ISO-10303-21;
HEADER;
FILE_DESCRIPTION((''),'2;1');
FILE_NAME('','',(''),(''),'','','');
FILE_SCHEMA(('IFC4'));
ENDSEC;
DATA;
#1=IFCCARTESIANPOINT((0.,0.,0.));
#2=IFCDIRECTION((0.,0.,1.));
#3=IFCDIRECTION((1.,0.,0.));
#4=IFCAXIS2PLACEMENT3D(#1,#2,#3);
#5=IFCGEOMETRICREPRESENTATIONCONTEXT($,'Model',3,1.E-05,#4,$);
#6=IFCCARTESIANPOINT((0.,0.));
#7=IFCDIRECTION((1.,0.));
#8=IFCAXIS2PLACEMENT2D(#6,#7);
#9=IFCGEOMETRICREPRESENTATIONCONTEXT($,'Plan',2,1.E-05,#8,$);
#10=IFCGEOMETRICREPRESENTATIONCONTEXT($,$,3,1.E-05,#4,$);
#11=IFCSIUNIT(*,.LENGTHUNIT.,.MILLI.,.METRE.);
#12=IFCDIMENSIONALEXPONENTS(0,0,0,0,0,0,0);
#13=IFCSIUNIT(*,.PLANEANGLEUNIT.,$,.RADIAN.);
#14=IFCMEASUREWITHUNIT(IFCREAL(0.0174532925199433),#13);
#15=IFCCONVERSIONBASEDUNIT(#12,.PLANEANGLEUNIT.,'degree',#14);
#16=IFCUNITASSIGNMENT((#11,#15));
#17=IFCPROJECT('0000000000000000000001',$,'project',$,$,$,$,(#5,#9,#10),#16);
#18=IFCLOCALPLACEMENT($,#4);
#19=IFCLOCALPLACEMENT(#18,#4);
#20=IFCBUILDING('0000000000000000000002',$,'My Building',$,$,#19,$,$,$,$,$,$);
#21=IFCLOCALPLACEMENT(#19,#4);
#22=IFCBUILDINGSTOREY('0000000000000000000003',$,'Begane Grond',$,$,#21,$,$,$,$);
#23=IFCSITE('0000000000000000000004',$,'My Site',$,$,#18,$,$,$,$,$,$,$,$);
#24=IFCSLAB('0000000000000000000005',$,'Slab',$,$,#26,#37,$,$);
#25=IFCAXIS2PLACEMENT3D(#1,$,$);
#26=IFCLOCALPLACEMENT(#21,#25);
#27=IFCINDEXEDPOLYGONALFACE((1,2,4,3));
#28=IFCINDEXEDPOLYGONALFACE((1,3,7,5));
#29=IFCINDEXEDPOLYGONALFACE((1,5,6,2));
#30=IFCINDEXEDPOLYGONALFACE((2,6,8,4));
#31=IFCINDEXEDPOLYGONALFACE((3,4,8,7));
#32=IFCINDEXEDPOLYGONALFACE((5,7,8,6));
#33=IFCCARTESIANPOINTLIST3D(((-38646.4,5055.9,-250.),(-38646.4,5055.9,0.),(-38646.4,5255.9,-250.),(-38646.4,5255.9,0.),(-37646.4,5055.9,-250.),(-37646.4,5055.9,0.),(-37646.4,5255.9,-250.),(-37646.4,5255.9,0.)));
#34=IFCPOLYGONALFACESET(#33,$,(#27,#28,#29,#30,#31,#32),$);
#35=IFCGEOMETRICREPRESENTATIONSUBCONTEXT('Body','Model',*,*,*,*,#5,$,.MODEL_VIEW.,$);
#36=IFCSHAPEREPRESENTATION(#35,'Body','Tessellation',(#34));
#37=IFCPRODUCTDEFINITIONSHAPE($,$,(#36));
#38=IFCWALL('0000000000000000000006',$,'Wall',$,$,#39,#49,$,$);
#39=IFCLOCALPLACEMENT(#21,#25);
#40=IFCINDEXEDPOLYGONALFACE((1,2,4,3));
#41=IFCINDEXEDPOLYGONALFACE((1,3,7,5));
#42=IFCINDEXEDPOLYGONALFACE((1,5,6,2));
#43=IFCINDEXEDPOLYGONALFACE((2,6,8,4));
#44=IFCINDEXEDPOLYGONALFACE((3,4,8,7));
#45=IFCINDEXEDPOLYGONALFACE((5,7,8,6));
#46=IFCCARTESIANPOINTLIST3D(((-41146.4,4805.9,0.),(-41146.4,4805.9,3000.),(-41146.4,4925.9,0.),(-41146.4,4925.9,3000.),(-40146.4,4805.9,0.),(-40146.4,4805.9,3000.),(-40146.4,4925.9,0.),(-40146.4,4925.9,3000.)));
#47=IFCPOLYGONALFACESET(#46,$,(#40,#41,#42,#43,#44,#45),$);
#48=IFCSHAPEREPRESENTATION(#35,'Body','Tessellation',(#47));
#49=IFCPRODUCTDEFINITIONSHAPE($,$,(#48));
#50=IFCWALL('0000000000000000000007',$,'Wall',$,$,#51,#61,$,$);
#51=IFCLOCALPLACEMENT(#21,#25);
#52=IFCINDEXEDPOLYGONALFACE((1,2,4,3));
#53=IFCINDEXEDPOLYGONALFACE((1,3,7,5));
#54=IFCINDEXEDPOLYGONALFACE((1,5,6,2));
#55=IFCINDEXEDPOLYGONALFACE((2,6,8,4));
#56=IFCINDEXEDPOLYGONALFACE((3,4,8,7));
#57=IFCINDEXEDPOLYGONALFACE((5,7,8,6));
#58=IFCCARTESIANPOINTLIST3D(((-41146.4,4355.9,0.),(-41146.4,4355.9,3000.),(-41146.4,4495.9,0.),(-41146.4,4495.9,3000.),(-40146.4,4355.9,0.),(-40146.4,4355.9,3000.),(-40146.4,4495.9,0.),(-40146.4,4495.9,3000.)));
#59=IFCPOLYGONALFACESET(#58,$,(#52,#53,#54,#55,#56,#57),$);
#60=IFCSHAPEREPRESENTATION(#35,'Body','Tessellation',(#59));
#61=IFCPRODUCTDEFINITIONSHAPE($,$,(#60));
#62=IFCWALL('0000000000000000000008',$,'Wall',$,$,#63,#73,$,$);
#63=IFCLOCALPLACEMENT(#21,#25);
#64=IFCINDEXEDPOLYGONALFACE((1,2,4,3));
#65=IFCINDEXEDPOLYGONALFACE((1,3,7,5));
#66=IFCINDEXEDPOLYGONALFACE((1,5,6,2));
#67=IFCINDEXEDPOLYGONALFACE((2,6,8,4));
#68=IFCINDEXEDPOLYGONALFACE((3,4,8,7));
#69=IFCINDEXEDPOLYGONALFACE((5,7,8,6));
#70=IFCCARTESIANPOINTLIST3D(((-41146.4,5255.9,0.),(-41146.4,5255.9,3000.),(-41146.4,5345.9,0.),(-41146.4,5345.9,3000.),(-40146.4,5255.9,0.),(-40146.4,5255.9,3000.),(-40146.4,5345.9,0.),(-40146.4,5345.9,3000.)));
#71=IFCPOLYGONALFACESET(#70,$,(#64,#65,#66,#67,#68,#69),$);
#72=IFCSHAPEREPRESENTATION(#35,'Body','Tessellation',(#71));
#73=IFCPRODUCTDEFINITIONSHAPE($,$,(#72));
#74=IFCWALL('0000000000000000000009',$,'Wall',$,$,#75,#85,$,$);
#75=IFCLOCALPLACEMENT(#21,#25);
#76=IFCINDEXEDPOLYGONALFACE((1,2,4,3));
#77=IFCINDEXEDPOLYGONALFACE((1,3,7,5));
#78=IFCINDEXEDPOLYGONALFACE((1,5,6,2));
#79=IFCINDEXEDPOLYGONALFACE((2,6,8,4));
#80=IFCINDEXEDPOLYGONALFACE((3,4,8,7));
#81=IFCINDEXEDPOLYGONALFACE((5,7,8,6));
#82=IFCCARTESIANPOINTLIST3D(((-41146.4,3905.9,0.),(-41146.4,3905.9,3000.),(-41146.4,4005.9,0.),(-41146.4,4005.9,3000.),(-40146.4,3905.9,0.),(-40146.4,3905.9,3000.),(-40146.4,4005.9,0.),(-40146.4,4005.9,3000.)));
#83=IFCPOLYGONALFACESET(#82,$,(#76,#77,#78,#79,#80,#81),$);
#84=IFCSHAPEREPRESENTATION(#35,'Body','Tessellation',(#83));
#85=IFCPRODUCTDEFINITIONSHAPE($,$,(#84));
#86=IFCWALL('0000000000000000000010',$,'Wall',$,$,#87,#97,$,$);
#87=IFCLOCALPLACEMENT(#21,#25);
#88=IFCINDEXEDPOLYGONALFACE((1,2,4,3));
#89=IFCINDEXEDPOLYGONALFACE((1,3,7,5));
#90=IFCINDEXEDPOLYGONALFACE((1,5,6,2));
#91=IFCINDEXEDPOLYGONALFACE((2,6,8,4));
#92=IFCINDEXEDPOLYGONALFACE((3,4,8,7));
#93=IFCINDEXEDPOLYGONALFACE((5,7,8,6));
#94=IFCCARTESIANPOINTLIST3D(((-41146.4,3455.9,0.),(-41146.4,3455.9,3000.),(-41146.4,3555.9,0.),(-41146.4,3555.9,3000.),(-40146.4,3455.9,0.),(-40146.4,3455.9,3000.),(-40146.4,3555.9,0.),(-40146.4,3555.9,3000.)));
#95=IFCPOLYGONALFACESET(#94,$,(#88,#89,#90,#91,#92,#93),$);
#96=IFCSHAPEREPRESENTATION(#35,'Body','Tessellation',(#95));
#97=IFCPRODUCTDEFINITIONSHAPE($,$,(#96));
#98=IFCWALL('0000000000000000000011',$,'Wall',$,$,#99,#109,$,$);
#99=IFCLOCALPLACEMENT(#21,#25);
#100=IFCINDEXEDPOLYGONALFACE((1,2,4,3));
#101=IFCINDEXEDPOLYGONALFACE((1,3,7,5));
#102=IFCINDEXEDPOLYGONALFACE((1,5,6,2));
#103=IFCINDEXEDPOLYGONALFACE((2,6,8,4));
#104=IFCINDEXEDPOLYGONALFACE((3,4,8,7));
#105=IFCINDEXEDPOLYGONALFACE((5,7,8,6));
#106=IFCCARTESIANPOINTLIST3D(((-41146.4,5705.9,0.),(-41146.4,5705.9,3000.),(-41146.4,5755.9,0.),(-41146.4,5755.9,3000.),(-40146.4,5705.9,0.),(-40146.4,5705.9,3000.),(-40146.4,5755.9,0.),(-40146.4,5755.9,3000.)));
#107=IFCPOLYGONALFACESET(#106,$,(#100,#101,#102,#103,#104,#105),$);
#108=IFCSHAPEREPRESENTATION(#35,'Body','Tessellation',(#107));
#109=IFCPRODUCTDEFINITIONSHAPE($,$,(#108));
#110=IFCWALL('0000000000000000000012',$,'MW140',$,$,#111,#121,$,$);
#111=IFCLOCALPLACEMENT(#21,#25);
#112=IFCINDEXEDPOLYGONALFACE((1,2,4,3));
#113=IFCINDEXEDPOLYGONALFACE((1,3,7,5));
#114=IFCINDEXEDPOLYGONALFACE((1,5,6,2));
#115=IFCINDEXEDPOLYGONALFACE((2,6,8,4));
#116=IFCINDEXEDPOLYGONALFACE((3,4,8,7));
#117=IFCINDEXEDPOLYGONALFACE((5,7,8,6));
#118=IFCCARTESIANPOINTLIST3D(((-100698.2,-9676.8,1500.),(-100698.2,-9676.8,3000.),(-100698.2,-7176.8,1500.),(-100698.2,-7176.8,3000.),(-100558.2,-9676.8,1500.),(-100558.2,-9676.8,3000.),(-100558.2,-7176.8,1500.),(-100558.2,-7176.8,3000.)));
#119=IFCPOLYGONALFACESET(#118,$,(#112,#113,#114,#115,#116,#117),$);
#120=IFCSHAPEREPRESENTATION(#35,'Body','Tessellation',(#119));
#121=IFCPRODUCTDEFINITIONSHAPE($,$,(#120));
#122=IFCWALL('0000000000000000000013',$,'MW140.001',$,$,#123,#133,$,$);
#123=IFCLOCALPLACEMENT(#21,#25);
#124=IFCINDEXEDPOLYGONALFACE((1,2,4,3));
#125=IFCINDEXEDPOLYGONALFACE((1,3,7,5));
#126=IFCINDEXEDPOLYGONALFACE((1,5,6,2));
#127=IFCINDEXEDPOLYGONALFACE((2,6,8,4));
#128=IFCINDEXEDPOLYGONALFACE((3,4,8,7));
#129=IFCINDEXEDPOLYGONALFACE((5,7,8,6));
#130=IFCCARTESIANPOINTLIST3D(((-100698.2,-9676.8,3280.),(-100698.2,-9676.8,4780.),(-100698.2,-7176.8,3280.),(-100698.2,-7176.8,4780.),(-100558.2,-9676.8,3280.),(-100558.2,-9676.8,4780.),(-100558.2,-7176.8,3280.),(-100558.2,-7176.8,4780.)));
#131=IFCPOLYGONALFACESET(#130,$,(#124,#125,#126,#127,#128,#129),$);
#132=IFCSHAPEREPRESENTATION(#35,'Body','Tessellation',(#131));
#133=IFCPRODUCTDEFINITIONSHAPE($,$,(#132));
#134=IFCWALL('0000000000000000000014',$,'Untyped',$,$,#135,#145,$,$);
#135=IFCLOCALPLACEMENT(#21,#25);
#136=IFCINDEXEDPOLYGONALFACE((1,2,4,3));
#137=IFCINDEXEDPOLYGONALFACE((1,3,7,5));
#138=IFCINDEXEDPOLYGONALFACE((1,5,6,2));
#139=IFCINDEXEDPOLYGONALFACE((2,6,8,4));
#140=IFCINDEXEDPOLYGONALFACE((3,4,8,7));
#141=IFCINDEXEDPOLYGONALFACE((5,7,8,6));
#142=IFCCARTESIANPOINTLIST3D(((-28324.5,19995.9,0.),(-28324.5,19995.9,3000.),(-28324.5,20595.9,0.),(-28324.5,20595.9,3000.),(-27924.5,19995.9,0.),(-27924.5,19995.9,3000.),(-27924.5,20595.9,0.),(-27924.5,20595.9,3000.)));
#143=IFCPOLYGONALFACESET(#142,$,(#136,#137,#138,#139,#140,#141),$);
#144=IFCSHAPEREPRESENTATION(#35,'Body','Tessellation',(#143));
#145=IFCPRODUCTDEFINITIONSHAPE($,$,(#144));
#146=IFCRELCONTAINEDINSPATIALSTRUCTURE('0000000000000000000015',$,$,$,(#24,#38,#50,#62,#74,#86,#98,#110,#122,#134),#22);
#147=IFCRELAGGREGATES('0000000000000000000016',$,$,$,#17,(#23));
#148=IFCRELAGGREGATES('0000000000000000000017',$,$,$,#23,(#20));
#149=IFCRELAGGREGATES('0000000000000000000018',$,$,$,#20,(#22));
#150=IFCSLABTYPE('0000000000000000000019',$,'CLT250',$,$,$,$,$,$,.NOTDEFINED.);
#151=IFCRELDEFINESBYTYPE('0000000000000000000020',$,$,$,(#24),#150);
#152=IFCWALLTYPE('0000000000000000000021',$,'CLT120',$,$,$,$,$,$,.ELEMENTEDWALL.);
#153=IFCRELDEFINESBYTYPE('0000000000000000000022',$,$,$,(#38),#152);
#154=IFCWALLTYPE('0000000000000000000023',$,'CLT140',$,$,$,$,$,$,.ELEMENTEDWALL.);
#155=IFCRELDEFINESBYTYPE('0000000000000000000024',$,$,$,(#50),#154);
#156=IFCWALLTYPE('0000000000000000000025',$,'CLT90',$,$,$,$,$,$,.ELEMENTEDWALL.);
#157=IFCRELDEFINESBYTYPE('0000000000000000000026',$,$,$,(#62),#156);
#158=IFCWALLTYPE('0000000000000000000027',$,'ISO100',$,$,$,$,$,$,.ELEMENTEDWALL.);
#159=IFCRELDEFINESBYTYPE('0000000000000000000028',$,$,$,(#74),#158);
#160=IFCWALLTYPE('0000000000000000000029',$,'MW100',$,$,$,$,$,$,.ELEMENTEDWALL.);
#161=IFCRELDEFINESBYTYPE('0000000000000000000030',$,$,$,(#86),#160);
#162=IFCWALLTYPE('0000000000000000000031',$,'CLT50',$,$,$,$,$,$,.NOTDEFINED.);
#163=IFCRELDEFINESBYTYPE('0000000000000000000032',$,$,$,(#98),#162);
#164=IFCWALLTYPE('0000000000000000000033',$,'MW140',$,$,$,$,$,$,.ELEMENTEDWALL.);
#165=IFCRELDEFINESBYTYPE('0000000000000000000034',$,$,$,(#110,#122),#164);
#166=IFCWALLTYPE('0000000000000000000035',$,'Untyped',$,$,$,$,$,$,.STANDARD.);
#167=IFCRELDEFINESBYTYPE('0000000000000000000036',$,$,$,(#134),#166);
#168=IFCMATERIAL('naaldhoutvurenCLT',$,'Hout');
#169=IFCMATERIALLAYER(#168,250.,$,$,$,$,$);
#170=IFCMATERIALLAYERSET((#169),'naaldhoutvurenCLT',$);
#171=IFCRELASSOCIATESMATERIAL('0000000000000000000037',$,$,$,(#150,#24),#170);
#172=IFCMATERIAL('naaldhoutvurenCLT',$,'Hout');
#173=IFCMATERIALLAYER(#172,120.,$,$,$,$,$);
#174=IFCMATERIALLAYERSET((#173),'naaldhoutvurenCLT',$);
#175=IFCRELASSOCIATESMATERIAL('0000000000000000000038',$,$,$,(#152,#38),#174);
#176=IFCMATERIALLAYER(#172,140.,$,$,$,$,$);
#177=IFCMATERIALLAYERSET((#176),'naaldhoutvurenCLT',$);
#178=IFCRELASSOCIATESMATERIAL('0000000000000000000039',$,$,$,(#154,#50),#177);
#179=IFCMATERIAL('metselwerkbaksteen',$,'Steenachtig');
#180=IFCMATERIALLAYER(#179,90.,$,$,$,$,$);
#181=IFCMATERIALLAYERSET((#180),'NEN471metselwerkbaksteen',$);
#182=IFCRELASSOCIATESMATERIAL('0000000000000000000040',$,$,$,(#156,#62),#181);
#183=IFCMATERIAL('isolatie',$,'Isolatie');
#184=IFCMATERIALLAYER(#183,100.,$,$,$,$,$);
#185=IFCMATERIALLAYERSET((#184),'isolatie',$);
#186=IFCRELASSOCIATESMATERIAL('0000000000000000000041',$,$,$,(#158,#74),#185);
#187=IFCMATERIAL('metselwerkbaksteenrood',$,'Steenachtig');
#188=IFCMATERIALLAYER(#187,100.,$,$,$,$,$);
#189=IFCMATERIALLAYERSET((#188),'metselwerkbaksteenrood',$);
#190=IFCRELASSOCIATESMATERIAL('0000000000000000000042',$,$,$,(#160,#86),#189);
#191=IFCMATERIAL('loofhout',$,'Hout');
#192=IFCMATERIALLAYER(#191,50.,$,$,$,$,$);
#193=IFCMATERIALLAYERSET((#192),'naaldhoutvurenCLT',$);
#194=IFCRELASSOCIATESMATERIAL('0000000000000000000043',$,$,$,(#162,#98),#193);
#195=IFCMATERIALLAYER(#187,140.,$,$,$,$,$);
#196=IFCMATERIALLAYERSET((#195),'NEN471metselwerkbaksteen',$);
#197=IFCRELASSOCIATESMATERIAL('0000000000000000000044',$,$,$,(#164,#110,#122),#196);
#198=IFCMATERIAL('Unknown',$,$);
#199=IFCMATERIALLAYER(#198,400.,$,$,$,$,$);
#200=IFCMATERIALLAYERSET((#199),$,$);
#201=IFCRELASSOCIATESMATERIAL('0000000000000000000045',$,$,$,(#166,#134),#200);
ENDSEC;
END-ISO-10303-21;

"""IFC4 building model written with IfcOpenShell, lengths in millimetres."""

from ifc_helpers import new_model, entity, si_unit, converted_unit, frame, origin_with_axes, origin_2d_with_axis, place, context, subcontext, project, spatial, line, indexed_curve, outline, extrude, material, layer, layer_set, layer_usage, type_object, element, save


model = new_model("IFC4")

# Units and contexts
model_context = context("Model", 3, precision=1e-05, world=origin_with_axes())
plan_context = context("Plan", 2, precision=1e-05, world=origin_2d_with_axis())
context_of_model = context(None, 3, precision=1e-05, world=origin_with_axes())
body_context = subcontext(model_context, "Body", "Model", "MODEL_VIEW")
ifc_project = project(units=[si_unit("LENGTHUNIT", "METRE", prefix="MILLI"), converted_unit("PLANEANGLEUNIT", "degree", entity("IfcReal", 0.0174532925199433), si_unit("PLANEANGLEUNIT", "RADIAN"), dimensions=[0, 0, 0, 0, 0, 0, 0])], contexts=[model_context, plan_context, context_of_model])

# Site, building, storey
site_placement = place(None, frame((0.0, 0.0, 0.0), z_axis=(0.0, 0.0, 1.0), x_axis=(1.0, 0.0, 0.0)))
site = spatial("IfcSite", under=ifc_project, at=site_placement, Name="My Site")
building_placement = place(site_placement, origin_with_axes())
building = spatial("IfcBuilding", under=site, at=building_placement, Name="My Building")
storey_placement = place(building_placement, origin_with_axes())
storey = spatial("IfcBuildingStorey", under=building, at=storey_placement, Name="Begane Grond")

# Slab
ifc_material_1 = material(Name="naaldhoutvurenCLT", Category="Hout")
ifc_material_2 = material(Name="isolatie", Category="Isolatie")
ifc_material_3 = material(Name="naaldhoutvurenCLT", Category="Hout")
ifc_layer_1 = layer(ifc_material_3, 250.0)
ifc_layer_set_1 = layer_set([ifc_layer_1], Name="naaldhoutvurenCLT")
ifc_layer_usage_1 = layer_usage(ifc_layer_set_1, "AXIS3", "POSITIVE", 0.0)
slab_type_1 = type_object("IfcSlabType", Name="CLT250", PredefinedType="NOTDEFINED", material=ifc_layer_set_1)
slab_1_placement = place(storey_placement, frame((-38646.4, 5055.9, -250.0), z_axis=(0.0, 0.0, 1.0), x_axis=(1.0, 0.0, 0.0)))
element("IfcSlab", 1, at=slab_1_placement, inside=storey, type_object=slab_type_1, material=ifc_layer_usage_1, Name="Slab", context=body_context, shape_type="SweptSolid", body=[
    extrude(outline(indexed_curve([(1000.0, 200.0), (1000.0, 0.0), (0.0, 0.0), (0.0, 200.0)], segments=[line(3, 2), line(2, 1), line(1, 4), line(4, 3)], self_intersect=False)), None, (0.0, 0.0, 1.0), 250.0),
])

# Walls
ifc_layer_2 = layer(ifc_material_1, 120.0)
ifc_layer_set_2 = layer_set([ifc_layer_2], Name="naaldhoutvurenCLT")
ifc_layer_usage_2 = layer_usage(ifc_layer_set_2, "AXIS2", "POSITIVE", 0.0)
wall_type_1 = type_object("IfcWallType", Name="CLT120", PredefinedType="ELEMENTEDWALL", material=ifc_layer_set_2)
wall_1_placement = place(storey_placement, frame((-41146.4, 4805.9, 0.0), z_axis=(0.0, 0.0, 1.0), x_axis=(1.0, 0.0, 0.0)))
element("IfcWall", 2, at=wall_1_placement, inside=storey, type_object=wall_type_1, material=ifc_layer_usage_2, Name="Wall", context=body_context, shape_type="SweptSolid", body=[
    extrude(outline(indexed_curve([(0.0, 0.0), (0.0, 120.0), (1000.0, 120.0), (1000.0, 0.0), (0.0, 0.0)], self_intersect=False)), origin_with_axes(), (0.0, 0.0, 1.0), 3000.0),
])
ifc_layer_3 = layer(ifc_material_1, 140.0)
ifc_layer_set_3 = layer_set([ifc_layer_3], Name="naaldhoutvurenCLT")
ifc_layer_usage_3 = layer_usage(ifc_layer_set_3, "AXIS2", "POSITIVE", 0.0)
wall_type_2 = type_object("IfcWallType", Name="CLT140", PredefinedType="ELEMENTEDWALL", material=ifc_layer_set_3)
wall_2_placement = place(storey_placement, frame((-41146.4, 4355.9, 0.0), z_axis=(0.0, 0.0, 1.0), x_axis=(1.0, 0.0, 0.0)))
element("IfcWall", 3, at=wall_2_placement, inside=storey, type_object=wall_type_2, material=ifc_layer_usage_3, Name="Wall", context=body_context, shape_type="SweptSolid", body=[
    extrude(outline(indexed_curve([(0.0, 0.0), (0.0, 140.0), (1000.0, 140.0), (1000.0, 0.0), (0.0, 0.0)], self_intersect=False)), origin_with_axes(), (0.0, 0.0, 1.0), 3000.0),
])
ifc_material_4 = material(Name="metselwerkbaksteen", Category="Steenachtig")
ifc_layer_4 = layer(ifc_material_4, 90.0)
ifc_layer_set_4 = layer_set([ifc_layer_4], Name="NEN471metselwerkbaksteen")
ifc_layer_usage_4 = layer_usage(ifc_layer_set_4, "AXIS2", "POSITIVE", 0.0)
wall_type_3 = type_object("IfcWallType", Name="CLT90", PredefinedType="ELEMENTEDWALL", material=ifc_layer_set_4)
wall_3_placement = place(storey_placement, frame((-41146.4, 5255.9, 0.0), z_axis=(0.0, 0.0, 1.0), x_axis=(1.0, 0.0, 0.0)))
element("IfcWall", 4, at=wall_3_placement, inside=storey, type_object=wall_type_3, material=ifc_layer_usage_4, Name="Wall", context=body_context, shape_type="SweptSolid", body=[
    extrude(outline(indexed_curve([(0.0, 0.0), (0.0, 90.0), (1000.0, 90.0), (1000.0, 0.0), (0.0, 0.0)], self_intersect=False)), origin_with_axes(), (0.0, 0.0, 1.0), 3000.0),
])
ifc_layer_5 = layer(ifc_material_2, 100.0)
ifc_layer_set_5 = layer_set([ifc_layer_5], Name="isolatie")
ifc_layer_usage_5 = layer_usage(ifc_layer_set_5, "AXIS2", "POSITIVE", 0.0)
wall_type_4 = type_object("IfcWallType", Name="ISO100", PredefinedType="ELEMENTEDWALL", material=ifc_layer_set_5)
wall_4_placement = place(storey_placement, frame((-41146.4, 3905.9, 0.0), z_axis=(0.0, 0.0, 1.0), x_axis=(1.0, 0.0, 0.0)))
element("IfcWall", 5, at=wall_4_placement, inside=storey, type_object=wall_type_4, material=ifc_layer_usage_5, Name="Wall", context=body_context, shape_type="SweptSolid", body=[
    extrude(outline(indexed_curve([(0.0, 0.0), (0.0, 100.0), (1000.0, 100.0), (1000.0, 0.0), (0.0, 0.0)], self_intersect=False)), origin_with_axes(), (0.0, 0.0, 1.0), 3000.0),
])
ifc_material_5 = material(Name="metselwerkbaksteenrood", Category="Steenachtig")
ifc_layer_6 = layer(ifc_material_5, 100.0)
ifc_layer_set_6 = layer_set([ifc_layer_6], Name="metselwerkbaksteenrood")
ifc_layer_usage_6 = layer_usage(ifc_layer_set_6, "AXIS2", "POSITIVE", 0.0)
wall_type_5 = type_object("IfcWallType", Name="MW100", PredefinedType="ELEMENTEDWALL", material=ifc_layer_set_6)
wall_5_placement = place(storey_placement, frame((-41146.4, 3455.9, 0.0), z_axis=(0.0, 0.0, 1.0), x_axis=(1.0, 0.0, 0.0)))
element("IfcWall", 6, at=wall_5_placement, inside=storey, type_object=wall_type_5, material=ifc_layer_usage_6, Name="Wall", context=body_context, shape_type="SweptSolid", body=[
    extrude(outline(indexed_curve([(0.0, 0.0), (0.0, 100.0), (1000.0, 100.0), (1000.0, 0.0), (0.0, 0.0)], self_intersect=False)), origin_with_axes(), (0.0, 0.0, 1.0), 3000.0),
])
ifc_material_6 = material(Name="loofhout", Category="Hout")
ifc_layer_7 = layer(ifc_material_6, 50.0)
ifc_layer_set_7 = layer_set([ifc_layer_7], Name="naaldhoutvurenCLT")
ifc_layer_usage_7 = layer_usage(ifc_layer_set_7, "AXIS2", "POSITIVE", 0.0)
wall_type_6 = type_object("IfcWallType", Name="CLT50", PredefinedType="NOTDEFINED", material=ifc_layer_set_7)
wall_6_placement = place(storey_placement, frame((-41146.4, 5705.9, 0.0), z_axis=(0.0, 0.0, 1.0), x_axis=(1.0, 0.0, 0.0)))
element("IfcWall", 7, at=wall_6_placement, inside=storey, type_object=wall_type_6, material=ifc_layer_usage_7, Name="Wall", context=body_context, shape_type="SweptSolid", body=[
    extrude(outline(indexed_curve([(0.0, 0.0), (0.0, 50.0), (1000.0, 50.0), (1000.0, 0.0), (0.0, 0.0)], self_intersect=False)), origin_with_axes(), (0.0, 0.0, 1.0), 3000.0),
])
ifc_layer_8 = layer(ifc_material_5, 140.0)
ifc_layer_set_8 = layer_set([ifc_layer_8], Name="NEN471metselwerkbaksteen")
ifc_layer_usage_8 = layer_usage(ifc_layer_set_8, "AXIS2", "POSITIVE", 0.0)
wall_type_7 = type_object("IfcWallType", Name="MW140", PredefinedType="ELEMENTEDWALL", material=ifc_layer_set_8)
wall_7_placement = place(storey_placement, frame((-100558.2, -9676.8, 1500.0), z_axis=(0.0, 0.0, 1.0), x_axis=(0.0, 1.0, 0.0)))
element("IfcWall", 8, at=wall_7_placement, inside=storey, type_object=wall_type_7, material=ifc_layer_usage_8, Name="MW140", context=body_context, shape_type="SweptSolid", body=[
    extrude(outline(indexed_curve([(0.0, 0.0), (0.0, 140.0), (2500.0, 140.0), (2500.0, 0.0), (0.0, 0.0)], self_intersect=False)), origin_with_axes(), (0.0, 0.0, 1.0), 1500.0),
])
ifc_layer_usage_9 = layer_usage(ifc_layer_set_8, "AXIS2", "POSITIVE", 0.0)
wall_8_placement = place(storey_placement, frame((-100558.2, -9676.8, 3280.0), z_axis=(0.0, 0.0, 1.0), x_axis=(0.0, 1.0, 0.0)))
element("IfcWall", 9, at=wall_8_placement, inside=storey, type_object=wall_type_7, material=ifc_layer_usage_9, Name="MW140.001", context=body_context, shape_type="SweptSolid", body=[
    extrude(outline(indexed_curve([(0.0, 0.0), (0.0, 140.0), (2500.0, 140.0), (2500.0, 0.0), (0.0, 0.0)], self_intersect=False)), origin_with_axes(), (0.0, 0.0, 1.0), 1500.0),
])
ifc_material_7 = material(Name="Unknown")
ifc_layer_9 = layer(ifc_material_7, 400.0)
ifc_layer_set_9 = layer_set([ifc_layer_9])
ifc_layer_usage_10 = layer_usage(ifc_layer_set_9, "AXIS2", "POSITIVE", 0.0)
wall_type_8 = type_object("IfcWallType", Name="Untyped", PredefinedType="STANDARD", material=ifc_layer_set_9)
wall_9_placement = place(storey_placement, frame((-27924.5, 19995.9, 0.0), z_axis=(0.0, 0.0, 1.0), x_axis=(0.0, 1.0, 0.0)))
element("IfcWall", 10, at=wall_9_placement, inside=storey, type_object=wall_type_8, material=ifc_layer_usage_10, Name="Untyped", context=body_context, shape_type="SweptSolid", body=[
    extrude(outline(indexed_curve([(0.0, 0.0), (0.0, 400.0), (600.0, 400.0), (600.0, 0.0), (0.0, 0.0)], self_intersect=False)), origin_with_axes(), (0.0, 0.0, 1.0), 3000.0),
])

save(model, "model.ifc")
